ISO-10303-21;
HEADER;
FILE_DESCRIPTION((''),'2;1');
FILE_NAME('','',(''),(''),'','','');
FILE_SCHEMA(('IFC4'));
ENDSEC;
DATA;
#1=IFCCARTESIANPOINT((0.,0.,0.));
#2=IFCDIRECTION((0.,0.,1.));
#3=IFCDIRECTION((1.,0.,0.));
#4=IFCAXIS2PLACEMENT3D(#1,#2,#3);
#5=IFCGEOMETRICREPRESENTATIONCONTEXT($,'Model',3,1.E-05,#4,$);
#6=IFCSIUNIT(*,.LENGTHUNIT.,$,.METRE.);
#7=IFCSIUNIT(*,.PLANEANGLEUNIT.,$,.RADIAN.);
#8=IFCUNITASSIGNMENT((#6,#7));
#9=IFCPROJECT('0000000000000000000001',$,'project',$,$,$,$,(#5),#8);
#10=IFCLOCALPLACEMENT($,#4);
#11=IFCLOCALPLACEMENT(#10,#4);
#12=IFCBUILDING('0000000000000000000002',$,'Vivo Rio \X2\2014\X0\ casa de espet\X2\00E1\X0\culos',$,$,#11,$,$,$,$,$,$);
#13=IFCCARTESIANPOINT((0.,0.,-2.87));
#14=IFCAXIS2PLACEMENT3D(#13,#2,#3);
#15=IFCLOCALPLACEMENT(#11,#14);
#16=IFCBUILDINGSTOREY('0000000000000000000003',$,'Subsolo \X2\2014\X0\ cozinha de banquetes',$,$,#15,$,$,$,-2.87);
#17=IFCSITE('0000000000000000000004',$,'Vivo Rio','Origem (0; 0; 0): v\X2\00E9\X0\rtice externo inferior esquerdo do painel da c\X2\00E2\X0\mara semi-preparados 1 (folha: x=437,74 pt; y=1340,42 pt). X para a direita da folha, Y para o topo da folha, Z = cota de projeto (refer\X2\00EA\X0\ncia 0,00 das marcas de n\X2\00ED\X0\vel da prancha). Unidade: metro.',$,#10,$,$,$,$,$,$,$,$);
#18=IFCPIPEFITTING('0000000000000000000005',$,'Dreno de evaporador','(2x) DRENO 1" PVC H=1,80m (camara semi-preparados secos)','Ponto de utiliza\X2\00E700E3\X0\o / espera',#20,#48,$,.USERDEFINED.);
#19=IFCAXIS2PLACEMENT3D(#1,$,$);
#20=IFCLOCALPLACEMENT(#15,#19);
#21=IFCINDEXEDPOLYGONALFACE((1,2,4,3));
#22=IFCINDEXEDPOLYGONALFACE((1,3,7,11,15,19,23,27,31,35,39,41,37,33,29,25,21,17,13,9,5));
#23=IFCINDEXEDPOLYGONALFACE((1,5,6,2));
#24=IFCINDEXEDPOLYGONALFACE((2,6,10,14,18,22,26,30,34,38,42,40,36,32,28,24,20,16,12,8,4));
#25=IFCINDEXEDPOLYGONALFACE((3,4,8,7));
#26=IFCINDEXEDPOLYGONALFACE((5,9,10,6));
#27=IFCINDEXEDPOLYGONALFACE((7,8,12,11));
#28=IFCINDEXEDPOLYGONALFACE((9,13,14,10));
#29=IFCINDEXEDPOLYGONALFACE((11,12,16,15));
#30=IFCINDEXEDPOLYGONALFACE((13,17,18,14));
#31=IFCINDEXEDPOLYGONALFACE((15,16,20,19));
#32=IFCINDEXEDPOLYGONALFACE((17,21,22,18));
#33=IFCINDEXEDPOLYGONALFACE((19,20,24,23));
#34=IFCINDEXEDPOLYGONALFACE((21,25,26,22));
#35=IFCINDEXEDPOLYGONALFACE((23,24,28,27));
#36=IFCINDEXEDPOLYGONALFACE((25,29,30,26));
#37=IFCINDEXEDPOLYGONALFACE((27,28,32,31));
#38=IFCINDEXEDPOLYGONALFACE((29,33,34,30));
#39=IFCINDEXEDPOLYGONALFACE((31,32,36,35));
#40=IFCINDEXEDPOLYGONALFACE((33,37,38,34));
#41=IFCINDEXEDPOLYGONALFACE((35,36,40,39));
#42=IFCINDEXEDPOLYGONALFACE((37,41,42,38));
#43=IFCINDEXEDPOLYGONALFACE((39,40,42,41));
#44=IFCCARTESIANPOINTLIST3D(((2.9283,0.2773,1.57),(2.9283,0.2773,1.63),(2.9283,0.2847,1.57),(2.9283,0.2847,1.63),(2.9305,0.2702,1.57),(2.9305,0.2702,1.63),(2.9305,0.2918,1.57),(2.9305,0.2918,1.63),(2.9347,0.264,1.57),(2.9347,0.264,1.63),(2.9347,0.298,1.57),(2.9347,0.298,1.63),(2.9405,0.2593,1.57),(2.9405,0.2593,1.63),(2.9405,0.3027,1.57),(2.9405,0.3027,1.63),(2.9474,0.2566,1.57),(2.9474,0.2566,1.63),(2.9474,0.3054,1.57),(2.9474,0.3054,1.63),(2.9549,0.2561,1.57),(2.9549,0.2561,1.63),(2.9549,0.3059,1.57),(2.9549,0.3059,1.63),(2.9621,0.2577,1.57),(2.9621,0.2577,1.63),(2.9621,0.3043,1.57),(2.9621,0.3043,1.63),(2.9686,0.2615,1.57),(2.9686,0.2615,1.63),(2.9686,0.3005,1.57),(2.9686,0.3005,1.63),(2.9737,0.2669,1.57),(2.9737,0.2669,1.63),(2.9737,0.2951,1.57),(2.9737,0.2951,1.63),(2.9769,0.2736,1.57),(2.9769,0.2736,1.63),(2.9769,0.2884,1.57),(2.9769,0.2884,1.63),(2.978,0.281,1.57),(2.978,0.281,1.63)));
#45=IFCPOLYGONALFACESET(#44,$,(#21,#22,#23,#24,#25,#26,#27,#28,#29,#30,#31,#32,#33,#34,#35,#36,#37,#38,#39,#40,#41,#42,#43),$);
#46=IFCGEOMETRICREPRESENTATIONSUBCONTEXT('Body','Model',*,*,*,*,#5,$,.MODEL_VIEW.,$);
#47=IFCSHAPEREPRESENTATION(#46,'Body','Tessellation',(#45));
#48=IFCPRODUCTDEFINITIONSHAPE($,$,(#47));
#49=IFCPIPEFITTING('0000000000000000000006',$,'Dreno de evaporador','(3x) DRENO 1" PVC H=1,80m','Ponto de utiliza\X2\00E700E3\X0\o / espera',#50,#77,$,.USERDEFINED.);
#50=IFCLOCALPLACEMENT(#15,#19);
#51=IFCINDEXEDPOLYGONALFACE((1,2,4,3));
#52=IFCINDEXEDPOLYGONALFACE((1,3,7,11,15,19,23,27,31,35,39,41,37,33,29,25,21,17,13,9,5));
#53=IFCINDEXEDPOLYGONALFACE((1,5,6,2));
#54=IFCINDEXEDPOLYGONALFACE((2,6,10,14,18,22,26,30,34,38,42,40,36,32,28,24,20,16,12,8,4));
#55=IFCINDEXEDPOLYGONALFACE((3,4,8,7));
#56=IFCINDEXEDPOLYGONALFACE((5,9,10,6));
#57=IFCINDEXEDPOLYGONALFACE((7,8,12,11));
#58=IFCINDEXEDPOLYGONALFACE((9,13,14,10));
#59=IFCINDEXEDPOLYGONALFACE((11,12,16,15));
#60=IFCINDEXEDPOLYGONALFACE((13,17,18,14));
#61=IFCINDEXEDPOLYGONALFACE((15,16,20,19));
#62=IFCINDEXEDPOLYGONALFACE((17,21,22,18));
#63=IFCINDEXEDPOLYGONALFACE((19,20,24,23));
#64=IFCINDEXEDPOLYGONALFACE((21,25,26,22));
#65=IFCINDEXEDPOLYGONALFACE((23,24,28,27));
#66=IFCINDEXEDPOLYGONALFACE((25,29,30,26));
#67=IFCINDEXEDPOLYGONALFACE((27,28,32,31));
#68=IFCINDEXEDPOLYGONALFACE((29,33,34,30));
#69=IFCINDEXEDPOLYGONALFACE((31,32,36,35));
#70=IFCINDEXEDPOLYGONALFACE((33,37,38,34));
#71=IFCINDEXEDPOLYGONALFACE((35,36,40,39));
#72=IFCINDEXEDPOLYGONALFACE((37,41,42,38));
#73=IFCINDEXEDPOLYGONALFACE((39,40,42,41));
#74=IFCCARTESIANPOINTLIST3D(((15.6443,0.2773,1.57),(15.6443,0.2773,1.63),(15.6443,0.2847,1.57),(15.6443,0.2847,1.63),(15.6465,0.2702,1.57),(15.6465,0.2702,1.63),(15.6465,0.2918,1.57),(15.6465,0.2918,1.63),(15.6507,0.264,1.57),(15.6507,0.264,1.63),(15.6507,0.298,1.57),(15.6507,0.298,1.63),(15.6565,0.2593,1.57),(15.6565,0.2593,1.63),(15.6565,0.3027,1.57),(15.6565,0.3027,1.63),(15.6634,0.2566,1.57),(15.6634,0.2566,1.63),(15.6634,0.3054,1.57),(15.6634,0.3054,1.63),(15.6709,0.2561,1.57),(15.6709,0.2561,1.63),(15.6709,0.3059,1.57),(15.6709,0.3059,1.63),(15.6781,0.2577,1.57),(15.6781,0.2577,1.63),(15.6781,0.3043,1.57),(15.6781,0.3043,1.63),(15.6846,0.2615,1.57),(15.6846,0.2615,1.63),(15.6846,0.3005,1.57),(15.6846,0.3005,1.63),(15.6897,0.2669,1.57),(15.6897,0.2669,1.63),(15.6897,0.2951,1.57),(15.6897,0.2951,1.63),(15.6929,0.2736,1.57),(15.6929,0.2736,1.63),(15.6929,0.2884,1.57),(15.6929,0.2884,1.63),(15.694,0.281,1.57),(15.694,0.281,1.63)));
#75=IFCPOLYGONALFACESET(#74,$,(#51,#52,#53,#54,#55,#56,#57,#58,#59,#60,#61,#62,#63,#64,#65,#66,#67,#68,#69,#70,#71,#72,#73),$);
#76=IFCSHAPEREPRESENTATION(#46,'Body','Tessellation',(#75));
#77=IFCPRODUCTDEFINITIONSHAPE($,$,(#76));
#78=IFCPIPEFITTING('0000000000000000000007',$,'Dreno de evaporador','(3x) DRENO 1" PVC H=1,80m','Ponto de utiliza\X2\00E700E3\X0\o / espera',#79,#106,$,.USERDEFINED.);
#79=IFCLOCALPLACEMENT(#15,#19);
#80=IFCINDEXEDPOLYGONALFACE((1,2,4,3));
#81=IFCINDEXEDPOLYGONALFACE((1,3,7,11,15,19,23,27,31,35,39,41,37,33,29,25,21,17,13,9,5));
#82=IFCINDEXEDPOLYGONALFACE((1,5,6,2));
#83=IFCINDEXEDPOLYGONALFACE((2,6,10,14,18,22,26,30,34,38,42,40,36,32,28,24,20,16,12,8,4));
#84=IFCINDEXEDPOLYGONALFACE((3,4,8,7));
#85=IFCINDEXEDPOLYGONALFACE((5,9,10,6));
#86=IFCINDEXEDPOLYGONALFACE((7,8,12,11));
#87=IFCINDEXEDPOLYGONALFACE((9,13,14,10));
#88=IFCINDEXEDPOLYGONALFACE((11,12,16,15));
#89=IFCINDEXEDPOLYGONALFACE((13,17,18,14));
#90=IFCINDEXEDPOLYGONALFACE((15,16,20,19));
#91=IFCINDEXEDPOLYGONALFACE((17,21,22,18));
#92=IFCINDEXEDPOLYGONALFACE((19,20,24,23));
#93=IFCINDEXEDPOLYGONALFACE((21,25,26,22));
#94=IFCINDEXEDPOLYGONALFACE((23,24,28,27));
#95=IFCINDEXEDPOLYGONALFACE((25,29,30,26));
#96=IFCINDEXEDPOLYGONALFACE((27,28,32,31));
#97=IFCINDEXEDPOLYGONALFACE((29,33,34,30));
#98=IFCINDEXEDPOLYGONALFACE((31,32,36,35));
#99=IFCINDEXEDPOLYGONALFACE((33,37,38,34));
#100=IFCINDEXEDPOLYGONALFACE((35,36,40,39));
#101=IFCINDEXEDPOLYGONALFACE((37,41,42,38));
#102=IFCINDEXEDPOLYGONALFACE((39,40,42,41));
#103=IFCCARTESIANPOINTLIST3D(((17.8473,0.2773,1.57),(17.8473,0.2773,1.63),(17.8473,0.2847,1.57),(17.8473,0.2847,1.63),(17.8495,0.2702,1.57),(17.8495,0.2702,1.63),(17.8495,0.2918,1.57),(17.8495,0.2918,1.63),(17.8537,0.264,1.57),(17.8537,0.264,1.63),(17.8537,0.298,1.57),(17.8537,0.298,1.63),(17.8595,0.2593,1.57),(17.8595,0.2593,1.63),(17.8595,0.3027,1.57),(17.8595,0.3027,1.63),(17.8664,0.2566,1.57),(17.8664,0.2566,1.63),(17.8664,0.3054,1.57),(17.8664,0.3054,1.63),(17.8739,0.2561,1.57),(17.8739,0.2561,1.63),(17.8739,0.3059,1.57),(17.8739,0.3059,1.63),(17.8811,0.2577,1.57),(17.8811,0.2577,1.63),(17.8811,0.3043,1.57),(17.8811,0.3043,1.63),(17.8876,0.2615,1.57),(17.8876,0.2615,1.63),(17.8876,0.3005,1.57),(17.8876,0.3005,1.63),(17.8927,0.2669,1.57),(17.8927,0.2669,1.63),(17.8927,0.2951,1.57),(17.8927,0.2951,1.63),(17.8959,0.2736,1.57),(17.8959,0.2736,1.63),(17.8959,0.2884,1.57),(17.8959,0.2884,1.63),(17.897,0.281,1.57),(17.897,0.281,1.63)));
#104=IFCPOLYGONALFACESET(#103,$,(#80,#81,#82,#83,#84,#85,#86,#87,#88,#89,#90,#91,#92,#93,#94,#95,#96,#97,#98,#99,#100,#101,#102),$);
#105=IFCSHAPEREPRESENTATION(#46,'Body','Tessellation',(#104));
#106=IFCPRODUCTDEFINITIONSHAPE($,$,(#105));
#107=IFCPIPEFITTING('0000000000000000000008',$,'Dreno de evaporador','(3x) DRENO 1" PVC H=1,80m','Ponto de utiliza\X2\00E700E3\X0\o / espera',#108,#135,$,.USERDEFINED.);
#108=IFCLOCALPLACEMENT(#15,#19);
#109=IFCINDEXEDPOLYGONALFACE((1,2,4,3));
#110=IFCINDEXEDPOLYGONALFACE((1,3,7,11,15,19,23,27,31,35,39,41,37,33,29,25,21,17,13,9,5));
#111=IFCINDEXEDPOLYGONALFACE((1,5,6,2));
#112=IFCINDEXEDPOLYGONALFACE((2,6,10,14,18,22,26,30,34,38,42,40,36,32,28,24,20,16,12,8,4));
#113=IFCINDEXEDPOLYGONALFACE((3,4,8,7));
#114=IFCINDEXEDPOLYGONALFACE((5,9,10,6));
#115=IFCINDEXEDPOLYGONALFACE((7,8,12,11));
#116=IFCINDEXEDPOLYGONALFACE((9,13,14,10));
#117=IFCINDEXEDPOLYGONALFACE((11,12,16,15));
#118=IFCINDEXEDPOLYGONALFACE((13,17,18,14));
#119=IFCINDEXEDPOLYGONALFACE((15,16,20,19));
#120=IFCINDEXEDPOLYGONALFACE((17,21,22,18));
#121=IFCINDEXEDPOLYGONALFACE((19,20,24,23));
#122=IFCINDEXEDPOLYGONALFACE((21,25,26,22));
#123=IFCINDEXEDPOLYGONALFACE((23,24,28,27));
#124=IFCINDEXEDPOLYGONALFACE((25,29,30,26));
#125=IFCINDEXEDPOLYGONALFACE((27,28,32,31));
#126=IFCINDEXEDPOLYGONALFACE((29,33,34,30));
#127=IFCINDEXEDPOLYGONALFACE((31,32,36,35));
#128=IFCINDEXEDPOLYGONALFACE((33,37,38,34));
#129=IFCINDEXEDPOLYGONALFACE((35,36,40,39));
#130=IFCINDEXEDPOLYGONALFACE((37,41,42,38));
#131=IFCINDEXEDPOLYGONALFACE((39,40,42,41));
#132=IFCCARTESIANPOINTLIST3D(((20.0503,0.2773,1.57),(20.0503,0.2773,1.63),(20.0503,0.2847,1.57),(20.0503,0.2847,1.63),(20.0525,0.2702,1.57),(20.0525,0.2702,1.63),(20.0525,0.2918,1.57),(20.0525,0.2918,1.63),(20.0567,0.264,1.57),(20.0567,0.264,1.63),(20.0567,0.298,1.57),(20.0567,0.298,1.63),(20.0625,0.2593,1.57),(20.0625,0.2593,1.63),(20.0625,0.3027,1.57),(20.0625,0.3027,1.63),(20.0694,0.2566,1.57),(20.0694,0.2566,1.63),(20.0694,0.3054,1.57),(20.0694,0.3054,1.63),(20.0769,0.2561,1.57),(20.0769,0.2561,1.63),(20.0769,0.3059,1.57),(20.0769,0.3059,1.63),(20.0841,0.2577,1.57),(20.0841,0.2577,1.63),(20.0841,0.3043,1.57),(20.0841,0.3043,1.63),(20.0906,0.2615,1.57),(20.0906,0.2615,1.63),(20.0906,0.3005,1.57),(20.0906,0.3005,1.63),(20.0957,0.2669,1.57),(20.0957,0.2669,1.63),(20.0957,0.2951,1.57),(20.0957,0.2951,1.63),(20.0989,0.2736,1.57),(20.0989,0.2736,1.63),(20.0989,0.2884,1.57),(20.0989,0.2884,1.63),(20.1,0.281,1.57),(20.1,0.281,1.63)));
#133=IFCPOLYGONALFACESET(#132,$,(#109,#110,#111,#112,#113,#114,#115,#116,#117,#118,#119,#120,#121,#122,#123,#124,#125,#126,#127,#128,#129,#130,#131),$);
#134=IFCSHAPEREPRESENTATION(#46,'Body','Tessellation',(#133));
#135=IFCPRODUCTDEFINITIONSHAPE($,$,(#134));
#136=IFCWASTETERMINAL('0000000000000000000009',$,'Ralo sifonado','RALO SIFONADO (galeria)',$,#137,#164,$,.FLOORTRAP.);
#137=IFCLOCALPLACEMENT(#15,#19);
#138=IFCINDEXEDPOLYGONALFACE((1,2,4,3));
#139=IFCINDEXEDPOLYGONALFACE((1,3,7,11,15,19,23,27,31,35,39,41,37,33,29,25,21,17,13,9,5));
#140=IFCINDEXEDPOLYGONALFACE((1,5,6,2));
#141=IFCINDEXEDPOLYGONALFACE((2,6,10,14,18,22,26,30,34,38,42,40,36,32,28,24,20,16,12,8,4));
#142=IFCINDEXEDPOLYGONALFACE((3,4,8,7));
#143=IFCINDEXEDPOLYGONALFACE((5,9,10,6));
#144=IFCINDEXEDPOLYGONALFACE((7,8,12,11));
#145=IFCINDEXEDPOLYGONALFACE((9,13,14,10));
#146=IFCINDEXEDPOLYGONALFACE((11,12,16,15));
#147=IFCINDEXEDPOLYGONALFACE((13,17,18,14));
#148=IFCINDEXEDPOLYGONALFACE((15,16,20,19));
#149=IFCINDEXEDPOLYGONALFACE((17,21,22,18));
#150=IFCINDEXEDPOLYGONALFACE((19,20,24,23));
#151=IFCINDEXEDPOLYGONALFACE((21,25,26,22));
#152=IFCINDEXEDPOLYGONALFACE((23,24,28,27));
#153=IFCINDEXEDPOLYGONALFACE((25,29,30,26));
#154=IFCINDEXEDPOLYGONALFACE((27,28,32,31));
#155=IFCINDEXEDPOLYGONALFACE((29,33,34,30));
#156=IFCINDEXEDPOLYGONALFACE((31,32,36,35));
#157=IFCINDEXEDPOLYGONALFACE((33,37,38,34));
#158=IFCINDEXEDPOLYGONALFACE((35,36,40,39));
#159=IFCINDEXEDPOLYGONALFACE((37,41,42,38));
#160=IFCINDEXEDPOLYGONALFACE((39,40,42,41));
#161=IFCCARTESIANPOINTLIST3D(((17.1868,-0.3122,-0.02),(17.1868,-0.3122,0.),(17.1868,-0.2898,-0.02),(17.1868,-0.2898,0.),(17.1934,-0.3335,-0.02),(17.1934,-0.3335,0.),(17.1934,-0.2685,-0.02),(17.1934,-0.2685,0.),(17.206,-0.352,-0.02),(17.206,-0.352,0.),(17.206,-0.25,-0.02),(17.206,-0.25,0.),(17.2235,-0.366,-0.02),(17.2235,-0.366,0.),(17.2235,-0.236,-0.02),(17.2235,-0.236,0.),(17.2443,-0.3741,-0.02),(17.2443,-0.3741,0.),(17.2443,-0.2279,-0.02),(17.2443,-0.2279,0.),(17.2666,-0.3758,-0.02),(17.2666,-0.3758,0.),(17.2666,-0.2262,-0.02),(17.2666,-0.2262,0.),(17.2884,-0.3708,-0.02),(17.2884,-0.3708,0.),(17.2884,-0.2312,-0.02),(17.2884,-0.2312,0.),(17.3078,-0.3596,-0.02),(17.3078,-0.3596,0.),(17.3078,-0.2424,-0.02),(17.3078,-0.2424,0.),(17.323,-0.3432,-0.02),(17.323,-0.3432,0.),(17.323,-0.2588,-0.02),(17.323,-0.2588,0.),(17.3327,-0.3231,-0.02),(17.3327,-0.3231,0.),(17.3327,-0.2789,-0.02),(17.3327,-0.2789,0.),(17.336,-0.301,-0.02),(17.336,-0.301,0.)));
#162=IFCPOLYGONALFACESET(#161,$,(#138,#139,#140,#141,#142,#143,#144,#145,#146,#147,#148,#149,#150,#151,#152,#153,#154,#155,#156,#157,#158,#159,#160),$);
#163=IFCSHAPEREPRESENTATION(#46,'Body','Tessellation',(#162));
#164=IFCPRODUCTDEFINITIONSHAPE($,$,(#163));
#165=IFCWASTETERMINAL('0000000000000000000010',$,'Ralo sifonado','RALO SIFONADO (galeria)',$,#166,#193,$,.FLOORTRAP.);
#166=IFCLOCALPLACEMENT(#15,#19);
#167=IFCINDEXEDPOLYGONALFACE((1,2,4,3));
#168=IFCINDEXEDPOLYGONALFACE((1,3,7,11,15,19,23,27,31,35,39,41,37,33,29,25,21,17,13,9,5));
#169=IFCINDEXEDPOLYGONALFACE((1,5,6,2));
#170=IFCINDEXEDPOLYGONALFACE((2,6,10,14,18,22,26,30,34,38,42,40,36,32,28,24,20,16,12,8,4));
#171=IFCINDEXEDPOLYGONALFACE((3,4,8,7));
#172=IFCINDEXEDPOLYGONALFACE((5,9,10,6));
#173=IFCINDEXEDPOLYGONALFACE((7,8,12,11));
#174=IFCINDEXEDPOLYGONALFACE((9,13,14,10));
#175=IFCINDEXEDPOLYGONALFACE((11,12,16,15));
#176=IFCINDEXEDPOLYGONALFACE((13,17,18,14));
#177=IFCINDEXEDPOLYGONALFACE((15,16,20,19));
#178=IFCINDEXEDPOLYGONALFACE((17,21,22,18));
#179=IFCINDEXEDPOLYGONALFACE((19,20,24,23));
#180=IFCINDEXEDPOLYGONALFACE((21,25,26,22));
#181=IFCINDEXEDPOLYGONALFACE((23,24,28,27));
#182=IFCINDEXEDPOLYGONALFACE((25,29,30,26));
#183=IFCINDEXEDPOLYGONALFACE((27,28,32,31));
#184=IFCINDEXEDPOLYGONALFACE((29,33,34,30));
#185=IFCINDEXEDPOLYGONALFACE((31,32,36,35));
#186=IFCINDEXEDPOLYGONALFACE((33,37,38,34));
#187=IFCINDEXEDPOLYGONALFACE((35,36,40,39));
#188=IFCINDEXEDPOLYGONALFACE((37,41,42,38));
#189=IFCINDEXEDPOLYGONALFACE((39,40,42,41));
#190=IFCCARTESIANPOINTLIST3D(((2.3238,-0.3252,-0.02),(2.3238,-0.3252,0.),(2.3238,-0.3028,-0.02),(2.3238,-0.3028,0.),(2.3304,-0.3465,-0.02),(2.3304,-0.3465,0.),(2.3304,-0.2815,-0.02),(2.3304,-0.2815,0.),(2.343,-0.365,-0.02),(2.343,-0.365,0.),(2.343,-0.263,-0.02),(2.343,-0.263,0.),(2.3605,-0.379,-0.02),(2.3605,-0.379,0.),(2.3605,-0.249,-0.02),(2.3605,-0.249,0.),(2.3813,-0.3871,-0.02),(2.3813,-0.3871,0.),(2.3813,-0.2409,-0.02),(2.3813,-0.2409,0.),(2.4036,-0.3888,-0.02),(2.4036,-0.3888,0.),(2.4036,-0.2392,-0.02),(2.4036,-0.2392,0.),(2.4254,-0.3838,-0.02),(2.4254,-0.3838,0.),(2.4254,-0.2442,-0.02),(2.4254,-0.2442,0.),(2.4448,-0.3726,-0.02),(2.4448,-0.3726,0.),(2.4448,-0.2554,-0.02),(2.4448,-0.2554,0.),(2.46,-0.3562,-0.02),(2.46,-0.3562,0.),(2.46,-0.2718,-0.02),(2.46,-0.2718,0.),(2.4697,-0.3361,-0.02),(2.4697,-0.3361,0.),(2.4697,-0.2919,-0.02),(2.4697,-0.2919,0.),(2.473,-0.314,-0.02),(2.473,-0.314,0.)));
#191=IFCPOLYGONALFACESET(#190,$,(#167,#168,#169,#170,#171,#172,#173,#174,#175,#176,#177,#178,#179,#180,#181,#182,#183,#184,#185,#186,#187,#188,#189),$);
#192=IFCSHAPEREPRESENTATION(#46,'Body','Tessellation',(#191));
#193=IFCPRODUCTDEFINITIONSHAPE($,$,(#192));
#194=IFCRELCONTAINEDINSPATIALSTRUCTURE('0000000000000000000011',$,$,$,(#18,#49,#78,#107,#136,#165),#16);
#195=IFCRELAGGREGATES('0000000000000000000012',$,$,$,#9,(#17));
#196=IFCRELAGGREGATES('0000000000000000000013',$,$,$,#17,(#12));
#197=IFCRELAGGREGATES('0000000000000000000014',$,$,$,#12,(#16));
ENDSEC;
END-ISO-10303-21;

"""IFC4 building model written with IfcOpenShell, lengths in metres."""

from ifc_helpers import new_model, si_unit, frame, origin_with_axes, origin_2d, place, context, subcontext, project, spatial, circle, extrude, element, save


model = new_model("IFC4")

# Units and contexts
model_context = context("Model", 3, precision=1e-05, world=origin_with_axes())
body_context = subcontext(model_context, "Body", "Model", "MODEL_VIEW")
ifc_project = project(units=[si_unit("LENGTHUNIT", "METRE"), si_unit("PLANEANGLEUNIT", "RADIAN")], contexts=[model_context])

# Site, building, storey
site_placement = place(None, origin_with_axes())
site = spatial("IfcSite", under=ifc_project, at=site_placement, Name="Vivo Rio", Description="Origem (0; 0; 0): vértice externo inferior esquerdo do painel da câmara semi-preparados 1 (folha: x=437,74 pt; y=1340,42 pt). X para a direita da folha, Y para o topo da folha, Z = cota de projeto (referência 0,00 das marcas de nível da prancha). Unidade: metro.")
building_placement = place(site_placement, origin_with_axes())
building = spatial("IfcBuilding", under=site, at=building_placement, Name="Vivo Rio — casa de espetáculos")
storey_placement = place(building_placement, frame((0.0, 0.0, -2.87), z_axis=(0.0, 0.0, 1.0), x_axis=(1.0, 0.0, 0.0)))
storey = spatial("IfcBuildingStorey", under=building, at=storey_placement, Name="Subsolo — cozinha de banquetes", Elevation=-2.87)

# Pipe fittings
pipe_fitting_1_placement = place(storey_placement, origin_with_axes())
element("IfcPipeFitting", 1, at=pipe_fitting_1_placement, inside=storey, Name="Dreno de evaporador", Description="(2x) DRENO 1\" PVC H=1,80m (camara semi-preparados secos)", ObjectType="Ponto de utilização / espera", PredefinedType="USERDEFINED", context=body_context, shape_type="SweptSolid", body=[
    extrude(circle(Radius=0.025, at=origin_2d()), frame((2.953, 0.281, 1.57), z_axis=(0.0, 0.0, 1.0), x_axis=(1.0, 0.0, 0.0)), (0.0, 0.0, 1.0), 0.06),
])
pipe_fitting_2_placement = place(storey_placement, origin_with_axes())
element("IfcPipeFitting", 2, at=pipe_fitting_2_placement, inside=storey, Name="Dreno de evaporador", Description="(3x) DRENO 1\" PVC H=1,80m", ObjectType="Ponto de utilização / espera", PredefinedType="USERDEFINED", context=body_context, shape_type="SweptSolid", body=[
    extrude(circle(Radius=0.025, at=origin_2d()), frame((15.669, 0.281, 1.57), z_axis=(0.0, 0.0, 1.0), x_axis=(1.0, 0.0, 0.0)), (0.0, 0.0, 1.0), 0.06),
])
pipe_fitting_3_placement = place(storey_placement, origin_with_axes())
element("IfcPipeFitting", 3, at=pipe_fitting_3_placement, inside=storey, Name="Dreno de evaporador", Description="(3x) DRENO 1\" PVC H=1,80m", ObjectType="Ponto de utilização / espera", PredefinedType="USERDEFINED", context=body_context, shape_type="SweptSolid", body=[
    extrude(circle(Radius=0.025, at=origin_2d()), frame((17.872, 0.281, 1.57), z_axis=(0.0, 0.0, 1.0), x_axis=(1.0, 0.0, 0.0)), (0.0, 0.0, 1.0), 0.06),
])
pipe_fitting_4_placement = place(storey_placement, origin_with_axes())
element("IfcPipeFitting", 4, at=pipe_fitting_4_placement, inside=storey, Name="Dreno de evaporador", Description="(3x) DRENO 1\" PVC H=1,80m", ObjectType="Ponto de utilização / espera", PredefinedType="USERDEFINED", context=body_context, shape_type="SweptSolid", body=[
    extrude(circle(Radius=0.025, at=origin_2d()), frame((20.075, 0.281, 1.57), z_axis=(0.0, 0.0, 1.0), x_axis=(1.0, 0.0, 0.0)), (0.0, 0.0, 1.0), 0.06),
])

# Waste terminals
waste_terminal_1_placement = place(storey_placement, origin_with_axes())
element("IfcWasteTerminal", 5, at=waste_terminal_1_placement, inside=storey, Name="Ralo sifonado", Description="RALO SIFONADO (galeria)", PredefinedType="FLOORTRAP", context=body_context, shape_type="SweptSolid", body=[
    extrude(circle(Radius=0.075, at=origin_2d()), frame((17.261, -0.301, -0.02), z_axis=(0.0, 0.0, 1.0), x_axis=(1.0, 0.0, 0.0)), (0.0, 0.0, 1.0), 0.02),
])
waste_terminal_2_placement = place(storey_placement, origin_with_axes())
element("IfcWasteTerminal", 6, at=waste_terminal_2_placement, inside=storey, Name="Ralo sifonado", Description="RALO SIFONADO (galeria)", PredefinedType="FLOORTRAP", context=body_context, shape_type="SweptSolid", body=[
    extrude(circle(Radius=0.075, at=origin_2d()), frame((2.398, -0.314, -0.02), z_axis=(0.0, 0.0, 1.0), x_axis=(1.0, 0.0, 0.0)), (0.0, 0.0, 1.0), 0.02),
])

save(model, "model.ifc")
